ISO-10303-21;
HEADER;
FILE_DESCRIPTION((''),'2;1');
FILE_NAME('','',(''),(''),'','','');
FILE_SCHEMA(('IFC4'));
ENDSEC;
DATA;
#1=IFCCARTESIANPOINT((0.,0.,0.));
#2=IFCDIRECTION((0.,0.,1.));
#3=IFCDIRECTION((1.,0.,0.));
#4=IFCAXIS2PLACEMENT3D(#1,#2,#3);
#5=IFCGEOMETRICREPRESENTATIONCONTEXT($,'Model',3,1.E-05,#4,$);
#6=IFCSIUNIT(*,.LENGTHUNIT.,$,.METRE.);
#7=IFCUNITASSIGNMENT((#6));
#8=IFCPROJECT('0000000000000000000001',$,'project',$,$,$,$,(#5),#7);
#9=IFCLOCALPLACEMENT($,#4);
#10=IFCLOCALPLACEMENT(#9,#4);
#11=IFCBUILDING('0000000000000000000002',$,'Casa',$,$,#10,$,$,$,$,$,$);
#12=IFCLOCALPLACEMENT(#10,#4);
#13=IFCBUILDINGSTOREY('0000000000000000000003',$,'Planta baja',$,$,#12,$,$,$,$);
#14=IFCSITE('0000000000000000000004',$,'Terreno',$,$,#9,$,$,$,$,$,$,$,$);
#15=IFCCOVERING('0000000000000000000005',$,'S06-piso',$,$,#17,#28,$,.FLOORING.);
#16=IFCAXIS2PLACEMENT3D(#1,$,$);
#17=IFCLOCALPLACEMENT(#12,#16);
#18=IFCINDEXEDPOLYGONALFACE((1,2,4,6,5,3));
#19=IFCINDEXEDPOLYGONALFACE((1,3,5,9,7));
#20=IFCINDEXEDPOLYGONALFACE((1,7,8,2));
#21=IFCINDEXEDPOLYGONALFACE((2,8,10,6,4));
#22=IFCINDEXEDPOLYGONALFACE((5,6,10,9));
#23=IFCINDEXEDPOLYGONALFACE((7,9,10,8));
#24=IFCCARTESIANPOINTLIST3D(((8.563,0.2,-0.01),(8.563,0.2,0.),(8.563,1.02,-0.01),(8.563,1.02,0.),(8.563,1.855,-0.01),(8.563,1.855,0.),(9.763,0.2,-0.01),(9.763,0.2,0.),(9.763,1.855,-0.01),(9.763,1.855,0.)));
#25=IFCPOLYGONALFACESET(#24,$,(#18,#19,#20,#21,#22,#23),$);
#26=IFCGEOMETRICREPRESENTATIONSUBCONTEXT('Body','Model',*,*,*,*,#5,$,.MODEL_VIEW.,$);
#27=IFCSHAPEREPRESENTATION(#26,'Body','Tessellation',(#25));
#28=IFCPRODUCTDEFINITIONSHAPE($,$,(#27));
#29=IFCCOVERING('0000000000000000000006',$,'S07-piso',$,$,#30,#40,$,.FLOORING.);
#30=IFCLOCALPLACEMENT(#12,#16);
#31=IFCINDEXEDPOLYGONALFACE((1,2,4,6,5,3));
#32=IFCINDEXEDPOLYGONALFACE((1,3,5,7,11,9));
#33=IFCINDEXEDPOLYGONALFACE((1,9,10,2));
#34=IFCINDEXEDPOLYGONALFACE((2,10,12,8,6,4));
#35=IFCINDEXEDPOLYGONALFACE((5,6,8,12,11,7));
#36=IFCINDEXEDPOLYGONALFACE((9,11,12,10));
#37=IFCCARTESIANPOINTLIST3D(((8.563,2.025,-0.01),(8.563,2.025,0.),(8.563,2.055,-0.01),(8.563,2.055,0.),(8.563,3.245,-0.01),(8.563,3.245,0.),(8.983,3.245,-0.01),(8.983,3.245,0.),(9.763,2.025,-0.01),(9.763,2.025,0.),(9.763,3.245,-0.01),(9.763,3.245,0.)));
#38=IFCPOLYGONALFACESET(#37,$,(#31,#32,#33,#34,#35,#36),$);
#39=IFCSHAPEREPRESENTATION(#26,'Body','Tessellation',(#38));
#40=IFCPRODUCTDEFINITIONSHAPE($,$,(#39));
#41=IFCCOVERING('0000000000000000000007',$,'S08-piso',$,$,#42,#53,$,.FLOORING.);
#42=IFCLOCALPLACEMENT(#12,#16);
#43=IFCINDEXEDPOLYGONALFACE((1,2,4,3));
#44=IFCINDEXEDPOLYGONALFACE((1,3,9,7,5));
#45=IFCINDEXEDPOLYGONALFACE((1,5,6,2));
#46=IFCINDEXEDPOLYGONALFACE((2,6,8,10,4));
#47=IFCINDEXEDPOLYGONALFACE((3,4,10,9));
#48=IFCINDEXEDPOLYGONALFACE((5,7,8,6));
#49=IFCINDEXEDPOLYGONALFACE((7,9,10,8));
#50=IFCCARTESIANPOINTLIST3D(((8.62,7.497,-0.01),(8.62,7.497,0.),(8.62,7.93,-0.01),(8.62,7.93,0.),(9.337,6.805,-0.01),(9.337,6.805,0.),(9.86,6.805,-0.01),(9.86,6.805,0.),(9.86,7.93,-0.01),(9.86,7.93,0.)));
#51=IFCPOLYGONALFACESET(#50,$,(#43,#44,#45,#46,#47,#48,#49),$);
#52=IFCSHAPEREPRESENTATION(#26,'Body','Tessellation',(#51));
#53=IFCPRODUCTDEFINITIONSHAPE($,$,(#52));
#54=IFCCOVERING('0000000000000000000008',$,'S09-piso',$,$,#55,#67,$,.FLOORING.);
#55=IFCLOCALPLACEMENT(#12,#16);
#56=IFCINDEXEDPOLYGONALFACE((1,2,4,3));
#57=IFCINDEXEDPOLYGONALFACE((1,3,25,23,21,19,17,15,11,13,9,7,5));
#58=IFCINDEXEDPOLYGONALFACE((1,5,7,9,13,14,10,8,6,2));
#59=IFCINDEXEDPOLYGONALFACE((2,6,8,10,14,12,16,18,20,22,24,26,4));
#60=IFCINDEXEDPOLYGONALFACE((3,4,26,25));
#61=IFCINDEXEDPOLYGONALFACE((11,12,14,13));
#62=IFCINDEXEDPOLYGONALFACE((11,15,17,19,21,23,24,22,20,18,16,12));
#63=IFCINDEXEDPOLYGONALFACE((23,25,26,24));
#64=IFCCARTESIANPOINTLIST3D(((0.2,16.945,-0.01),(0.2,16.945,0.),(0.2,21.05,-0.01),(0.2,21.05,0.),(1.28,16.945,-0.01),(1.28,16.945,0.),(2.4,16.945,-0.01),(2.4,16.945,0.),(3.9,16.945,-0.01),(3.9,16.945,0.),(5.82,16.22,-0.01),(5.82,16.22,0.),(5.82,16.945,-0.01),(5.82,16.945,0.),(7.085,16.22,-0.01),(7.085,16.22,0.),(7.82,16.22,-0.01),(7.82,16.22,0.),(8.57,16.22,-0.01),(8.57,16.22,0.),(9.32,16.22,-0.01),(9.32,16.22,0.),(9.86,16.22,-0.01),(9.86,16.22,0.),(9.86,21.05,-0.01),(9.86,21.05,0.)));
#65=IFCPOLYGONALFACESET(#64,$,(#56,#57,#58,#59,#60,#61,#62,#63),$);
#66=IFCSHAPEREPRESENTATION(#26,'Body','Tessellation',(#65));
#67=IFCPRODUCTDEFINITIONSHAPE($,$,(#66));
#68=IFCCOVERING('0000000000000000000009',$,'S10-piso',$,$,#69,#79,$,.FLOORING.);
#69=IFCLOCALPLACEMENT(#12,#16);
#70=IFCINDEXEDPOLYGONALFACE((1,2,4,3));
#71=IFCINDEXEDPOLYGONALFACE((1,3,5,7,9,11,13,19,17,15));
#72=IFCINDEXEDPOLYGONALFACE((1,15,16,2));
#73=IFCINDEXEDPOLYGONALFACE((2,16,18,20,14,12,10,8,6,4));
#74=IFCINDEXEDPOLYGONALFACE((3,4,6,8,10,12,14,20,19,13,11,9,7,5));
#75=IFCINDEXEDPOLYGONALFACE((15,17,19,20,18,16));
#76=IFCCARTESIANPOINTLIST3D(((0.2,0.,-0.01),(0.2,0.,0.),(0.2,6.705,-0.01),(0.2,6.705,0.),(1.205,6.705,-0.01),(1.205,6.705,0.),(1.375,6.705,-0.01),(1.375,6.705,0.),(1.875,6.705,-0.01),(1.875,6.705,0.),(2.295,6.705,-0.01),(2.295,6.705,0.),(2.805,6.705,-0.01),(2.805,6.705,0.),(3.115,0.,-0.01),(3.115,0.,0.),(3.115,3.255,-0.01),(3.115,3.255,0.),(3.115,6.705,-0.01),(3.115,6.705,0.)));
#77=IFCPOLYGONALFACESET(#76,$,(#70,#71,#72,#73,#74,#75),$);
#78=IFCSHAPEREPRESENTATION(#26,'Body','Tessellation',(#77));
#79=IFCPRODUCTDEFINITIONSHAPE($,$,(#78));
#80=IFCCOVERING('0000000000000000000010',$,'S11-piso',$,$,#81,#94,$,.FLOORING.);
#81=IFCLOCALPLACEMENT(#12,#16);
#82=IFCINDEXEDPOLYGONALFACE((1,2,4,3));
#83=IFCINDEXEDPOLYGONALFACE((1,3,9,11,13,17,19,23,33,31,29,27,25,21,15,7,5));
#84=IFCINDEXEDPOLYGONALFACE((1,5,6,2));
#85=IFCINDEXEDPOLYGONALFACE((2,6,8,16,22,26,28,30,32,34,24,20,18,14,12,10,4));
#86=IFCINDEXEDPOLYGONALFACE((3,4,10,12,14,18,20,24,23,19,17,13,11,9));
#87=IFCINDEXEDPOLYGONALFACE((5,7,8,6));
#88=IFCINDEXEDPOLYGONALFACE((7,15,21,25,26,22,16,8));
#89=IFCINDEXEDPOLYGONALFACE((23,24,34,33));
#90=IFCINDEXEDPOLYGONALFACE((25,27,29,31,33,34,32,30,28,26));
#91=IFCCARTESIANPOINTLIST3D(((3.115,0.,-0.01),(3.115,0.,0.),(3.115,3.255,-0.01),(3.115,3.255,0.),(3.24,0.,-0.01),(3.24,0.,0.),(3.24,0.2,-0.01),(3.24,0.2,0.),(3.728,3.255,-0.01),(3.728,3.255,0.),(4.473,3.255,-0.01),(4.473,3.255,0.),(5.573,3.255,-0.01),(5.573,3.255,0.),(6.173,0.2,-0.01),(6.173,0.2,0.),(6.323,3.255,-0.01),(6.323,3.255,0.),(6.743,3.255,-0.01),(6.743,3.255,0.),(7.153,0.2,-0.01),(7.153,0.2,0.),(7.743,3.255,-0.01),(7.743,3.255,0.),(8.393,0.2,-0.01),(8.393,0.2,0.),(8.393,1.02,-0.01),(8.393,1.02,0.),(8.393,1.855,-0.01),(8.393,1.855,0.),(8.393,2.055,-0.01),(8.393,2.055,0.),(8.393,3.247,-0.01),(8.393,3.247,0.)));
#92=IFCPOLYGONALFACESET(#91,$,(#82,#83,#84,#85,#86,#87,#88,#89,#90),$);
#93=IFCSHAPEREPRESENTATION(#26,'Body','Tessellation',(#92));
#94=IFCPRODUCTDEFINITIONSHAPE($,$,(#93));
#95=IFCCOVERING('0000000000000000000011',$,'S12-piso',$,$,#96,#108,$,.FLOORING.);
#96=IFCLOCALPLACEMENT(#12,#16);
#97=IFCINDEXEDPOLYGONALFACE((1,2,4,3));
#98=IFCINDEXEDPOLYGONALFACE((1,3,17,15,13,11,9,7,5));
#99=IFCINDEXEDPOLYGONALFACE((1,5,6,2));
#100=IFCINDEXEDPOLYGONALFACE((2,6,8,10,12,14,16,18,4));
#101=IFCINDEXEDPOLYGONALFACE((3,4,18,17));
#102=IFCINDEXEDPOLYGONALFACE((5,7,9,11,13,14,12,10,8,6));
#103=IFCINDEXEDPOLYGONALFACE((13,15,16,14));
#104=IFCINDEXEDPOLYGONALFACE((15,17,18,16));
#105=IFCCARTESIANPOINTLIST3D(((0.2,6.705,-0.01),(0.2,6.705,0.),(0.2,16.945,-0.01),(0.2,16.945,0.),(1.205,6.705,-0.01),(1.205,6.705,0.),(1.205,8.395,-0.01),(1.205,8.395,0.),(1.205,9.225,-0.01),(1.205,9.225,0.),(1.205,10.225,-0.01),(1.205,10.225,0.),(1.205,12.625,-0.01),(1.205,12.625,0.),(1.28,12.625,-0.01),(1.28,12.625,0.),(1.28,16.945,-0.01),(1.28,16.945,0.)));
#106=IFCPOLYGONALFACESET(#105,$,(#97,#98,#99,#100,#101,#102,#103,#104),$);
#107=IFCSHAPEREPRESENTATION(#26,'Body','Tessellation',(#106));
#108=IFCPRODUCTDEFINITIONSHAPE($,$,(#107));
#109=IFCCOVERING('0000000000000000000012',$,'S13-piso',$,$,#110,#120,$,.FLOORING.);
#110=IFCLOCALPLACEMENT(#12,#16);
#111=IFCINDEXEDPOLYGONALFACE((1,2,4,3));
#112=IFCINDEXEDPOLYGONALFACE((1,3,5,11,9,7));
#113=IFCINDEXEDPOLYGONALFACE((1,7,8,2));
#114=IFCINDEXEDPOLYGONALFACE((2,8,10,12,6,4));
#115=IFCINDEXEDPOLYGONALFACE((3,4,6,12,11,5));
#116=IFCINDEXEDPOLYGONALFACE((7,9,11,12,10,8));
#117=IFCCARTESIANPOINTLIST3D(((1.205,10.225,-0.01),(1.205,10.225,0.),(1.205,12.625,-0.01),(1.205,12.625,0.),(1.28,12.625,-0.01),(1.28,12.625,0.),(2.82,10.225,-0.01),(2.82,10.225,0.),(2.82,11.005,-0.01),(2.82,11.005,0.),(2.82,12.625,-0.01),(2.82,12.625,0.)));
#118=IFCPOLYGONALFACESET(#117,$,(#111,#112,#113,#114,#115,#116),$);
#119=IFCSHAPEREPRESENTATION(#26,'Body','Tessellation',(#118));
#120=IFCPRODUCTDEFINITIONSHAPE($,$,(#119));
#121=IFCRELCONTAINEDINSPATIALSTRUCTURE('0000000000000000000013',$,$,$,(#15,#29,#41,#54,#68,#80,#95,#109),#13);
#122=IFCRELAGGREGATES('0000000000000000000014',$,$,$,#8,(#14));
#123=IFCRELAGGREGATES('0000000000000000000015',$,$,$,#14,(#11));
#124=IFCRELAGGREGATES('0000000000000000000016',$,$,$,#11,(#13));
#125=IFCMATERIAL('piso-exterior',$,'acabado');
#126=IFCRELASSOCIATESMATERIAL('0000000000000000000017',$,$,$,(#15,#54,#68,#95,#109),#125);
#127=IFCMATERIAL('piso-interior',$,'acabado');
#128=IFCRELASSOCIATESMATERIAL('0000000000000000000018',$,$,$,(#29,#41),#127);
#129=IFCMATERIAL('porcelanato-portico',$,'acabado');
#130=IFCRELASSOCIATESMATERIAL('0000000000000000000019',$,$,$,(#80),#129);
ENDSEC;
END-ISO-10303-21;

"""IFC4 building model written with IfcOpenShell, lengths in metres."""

from ifc_helpers import new_model, si_unit, frame, origin_with_axes, place, context, subcontext, project, spatial, line, indexed_curve, outline, extrude, material, element, save


model = new_model("IFC4")

# Units and contexts
model_context = context("Model", 3, precision=1e-05, world=origin_with_axes())
body_context = subcontext(model_context, "Body", "Model", "MODEL_VIEW")
ifc_project = project(units=[si_unit("LENGTHUNIT", "METRE")], contexts=[model_context])

# Site, building, storey
site_placement = place(None, origin_with_axes())
site = spatial("IfcSite", under=ifc_project, at=site_placement, Name="Terreno")
building_placement = place(site_placement, origin_with_axes())
building = spatial("IfcBuilding", under=site, at=building_placement, Name="Casa")
storey_placement = place(building_placement, origin_with_axes())
storey = spatial("IfcBuildingStorey", under=building, at=storey_placement, Name="Planta baja")

# Coverings
ifc_material_1 = material(Name="piso-interior", Category="acabado")
ifc_material_2 = material(Name="piso-exterior", Category="acabado")
covering_1_placement = place(storey_placement, origin_with_axes())
element("IfcCovering", 1, at=covering_1_placement, inside=storey, material=ifc_material_2, Name="S06-piso", PredefinedType="FLOORING", context=body_context, shape_type="SweptSolid", body=[
    extrude(outline(indexed_curve([(8.563, 1.02), (8.563, 1.855), (9.763, 1.855), (9.763, 0.2), (8.563, 0.2)], segments=[line(1, 2, 3, 4, 5, 1)])), frame((0.0, 0.0, -0.01), z_axis=(0.0, 0.0, 1.0), x_axis=(1.0, 0.0, 0.0)), (0.0, 0.0, 1.0), 0.01),
])
covering_2_placement = place(storey_placement, origin_with_axes())
element("IfcCovering", 2, at=covering_2_placement, inside=storey, material=ifc_material_1, Name="S07-piso", PredefinedType="FLOORING", context=body_context, shape_type="SweptSolid", body=[
    extrude(outline(indexed_curve([(8.983, 3.245), (9.763, 3.245), (9.763, 2.025), (8.563, 2.025), (8.563, 2.055), (8.563, 3.245)], segments=[line(1, 2, 3, 4, 5, 6, 1)])), frame((0.0, 0.0, -0.01), z_axis=(0.0, 0.0, 1.0), x_axis=(1.0, 0.0, 0.0)), (0.0, 0.0, 1.0), 0.01),
])
covering_3_placement = place(storey_placement, origin_with_axes())
element("IfcCovering", 3, at=covering_3_placement, inside=storey, material=ifc_material_1, Name="S08-piso", PredefinedType="FLOORING", context=body_context, shape_type="SweptSolid", body=[
    extrude(outline(indexed_curve([(9.86, 6.805), (9.337, 6.805), (8.62, 7.497), (8.62, 7.93), (9.86, 7.93)], segments=[line(1, 2, 3, 4, 5, 1)])), frame((0.0, 0.0, -0.01), z_axis=(0.0, 0.0, 1.0), x_axis=(1.0, 0.0, 0.0)), (0.0, 0.0, 1.0), 0.01),
])
covering_4_placement = place(storey_placement, origin_with_axes())
element("IfcCovering", 4, at=covering_4_placement, inside=storey, material=ifc_material_2, Name="S09-piso", PredefinedType="FLOORING", context=body_context, shape_type="SweptSolid", body=[
    extrude(outline(indexed_curve([(9.86, 16.22), (9.32, 16.22), (8.57, 16.22), (7.82, 16.22), (7.085, 16.22), (5.82, 16.22), (5.82, 16.945), (3.9, 16.945), (2.4, 16.945), (1.28, 16.945), (0.2, 16.945), (0.2, 21.05), (9.86, 21.05)], segments=[line(1, 2, 3, 4, 5, 6, 7, 8, 9, 10, 11, 12, 13, 1)])), frame((0.0, 0.0, -0.01), z_axis=(0.0, 0.0, 1.0), x_axis=(1.0, 0.0, 0.0)), (0.0, 0.0, 1.0), 0.01),
])
covering_5_placement = place(storey_placement, origin_with_axes())
element("IfcCovering", 5, at=covering_5_placement, inside=storey, material=ifc_material_2, Name="S10-piso", PredefinedType="FLOORING", context=body_context, shape_type="SweptSolid", body=[
    extrude(outline(indexed_curve([(1.875, 6.705), (2.295, 6.705), (2.805, 6.705), (3.115, 6.705), (3.115, 3.255), (3.115, 0.0), (0.2, 0.0), (0.2, 6.705), (1.205, 6.705), (1.375, 6.705)], segments=[line(1, 2, 3, 4, 5, 6, 7, 8, 9, 10, 1)])), frame((0.0, 0.0, -0.01), z_axis=(0.0, 0.0, 1.0), x_axis=(1.0, 0.0, 0.0)), (0.0, 0.0, 1.0), 0.01),
])
ifc_material_3 = material(Name="porcelanato-portico", Category="acabado")
covering_6_placement = place(storey_placement, origin_with_axes())
element("IfcCovering", 6, at=covering_6_placement, inside=storey, material=ifc_material_3, Name="S11-piso", PredefinedType="FLOORING", context=body_context, shape_type="SweptSolid", body=[
    extrude(outline(indexed_curve([(6.323, 3.255), (6.743, 3.255), (7.743, 3.255), (8.393, 3.247), (8.393, 2.055), (8.393, 1.855), (8.393, 1.02), (8.393, 0.2), (7.153, 0.2), (6.173, 0.2), (3.24, 0.2), (3.24, 0.0), (3.115, 0.0), (3.115, 3.255), (3.728, 3.255), (4.473, 3.255), (5.573, 3.255)], segments=[line(1, 2, 3, 4, 5, 6, 7, 8, 9, 10, 11, 12, 13, 14, 15, 16, 17, 1)])), frame((0.0, 0.0, -0.01), z_axis=(0.0, 0.0, 1.0), x_axis=(1.0, 0.0, 0.0)), (0.0, 0.0, 1.0), 0.01),
])
covering_7_placement = place(storey_placement, origin_with_axes())
element("IfcCovering", 7, at=covering_7_placement, inside=storey, material=ifc_material_2, Name="S12-piso", PredefinedType="FLOORING", context=body_context, shape_type="SweptSolid", body=[
    extrude(outline(indexed_curve([(1.205, 9.225), (1.205, 8.395), (1.205, 6.705), (0.2, 6.705), (0.2, 16.945), (1.28, 16.945), (1.28, 12.625), (1.205, 12.625), (1.205, 10.225)], segments=[line(1, 2, 3, 4, 5, 6, 7, 8, 9, 1)])), frame((0.0, 0.0, -0.01), z_axis=(0.0, 0.0, 1.0), x_axis=(1.0, 0.0, 0.0)), (0.0, 0.0, 1.0), 0.01),
])
covering_8_placement = place(storey_placement, origin_with_axes())
element("IfcCovering", 8, at=covering_8_placement, inside=storey, material=ifc_material_2, Name="S13-piso", PredefinedType="FLOORING", context=body_context, shape_type="SweptSolid", body=[
    extrude(outline(indexed_curve([(2.82, 11.005), (2.82, 10.225), (1.205, 10.225), (1.205, 12.625), (1.28, 12.625), (2.82, 12.625)], segments=[line(1, 2, 3, 4, 5, 6, 1)])), frame((0.0, 0.0, -0.01), z_axis=(0.0, 0.0, 1.0), x_axis=(1.0, 0.0, 0.0)), (0.0, 0.0, 1.0), 0.01),
])

save(model, "model.ifc")
